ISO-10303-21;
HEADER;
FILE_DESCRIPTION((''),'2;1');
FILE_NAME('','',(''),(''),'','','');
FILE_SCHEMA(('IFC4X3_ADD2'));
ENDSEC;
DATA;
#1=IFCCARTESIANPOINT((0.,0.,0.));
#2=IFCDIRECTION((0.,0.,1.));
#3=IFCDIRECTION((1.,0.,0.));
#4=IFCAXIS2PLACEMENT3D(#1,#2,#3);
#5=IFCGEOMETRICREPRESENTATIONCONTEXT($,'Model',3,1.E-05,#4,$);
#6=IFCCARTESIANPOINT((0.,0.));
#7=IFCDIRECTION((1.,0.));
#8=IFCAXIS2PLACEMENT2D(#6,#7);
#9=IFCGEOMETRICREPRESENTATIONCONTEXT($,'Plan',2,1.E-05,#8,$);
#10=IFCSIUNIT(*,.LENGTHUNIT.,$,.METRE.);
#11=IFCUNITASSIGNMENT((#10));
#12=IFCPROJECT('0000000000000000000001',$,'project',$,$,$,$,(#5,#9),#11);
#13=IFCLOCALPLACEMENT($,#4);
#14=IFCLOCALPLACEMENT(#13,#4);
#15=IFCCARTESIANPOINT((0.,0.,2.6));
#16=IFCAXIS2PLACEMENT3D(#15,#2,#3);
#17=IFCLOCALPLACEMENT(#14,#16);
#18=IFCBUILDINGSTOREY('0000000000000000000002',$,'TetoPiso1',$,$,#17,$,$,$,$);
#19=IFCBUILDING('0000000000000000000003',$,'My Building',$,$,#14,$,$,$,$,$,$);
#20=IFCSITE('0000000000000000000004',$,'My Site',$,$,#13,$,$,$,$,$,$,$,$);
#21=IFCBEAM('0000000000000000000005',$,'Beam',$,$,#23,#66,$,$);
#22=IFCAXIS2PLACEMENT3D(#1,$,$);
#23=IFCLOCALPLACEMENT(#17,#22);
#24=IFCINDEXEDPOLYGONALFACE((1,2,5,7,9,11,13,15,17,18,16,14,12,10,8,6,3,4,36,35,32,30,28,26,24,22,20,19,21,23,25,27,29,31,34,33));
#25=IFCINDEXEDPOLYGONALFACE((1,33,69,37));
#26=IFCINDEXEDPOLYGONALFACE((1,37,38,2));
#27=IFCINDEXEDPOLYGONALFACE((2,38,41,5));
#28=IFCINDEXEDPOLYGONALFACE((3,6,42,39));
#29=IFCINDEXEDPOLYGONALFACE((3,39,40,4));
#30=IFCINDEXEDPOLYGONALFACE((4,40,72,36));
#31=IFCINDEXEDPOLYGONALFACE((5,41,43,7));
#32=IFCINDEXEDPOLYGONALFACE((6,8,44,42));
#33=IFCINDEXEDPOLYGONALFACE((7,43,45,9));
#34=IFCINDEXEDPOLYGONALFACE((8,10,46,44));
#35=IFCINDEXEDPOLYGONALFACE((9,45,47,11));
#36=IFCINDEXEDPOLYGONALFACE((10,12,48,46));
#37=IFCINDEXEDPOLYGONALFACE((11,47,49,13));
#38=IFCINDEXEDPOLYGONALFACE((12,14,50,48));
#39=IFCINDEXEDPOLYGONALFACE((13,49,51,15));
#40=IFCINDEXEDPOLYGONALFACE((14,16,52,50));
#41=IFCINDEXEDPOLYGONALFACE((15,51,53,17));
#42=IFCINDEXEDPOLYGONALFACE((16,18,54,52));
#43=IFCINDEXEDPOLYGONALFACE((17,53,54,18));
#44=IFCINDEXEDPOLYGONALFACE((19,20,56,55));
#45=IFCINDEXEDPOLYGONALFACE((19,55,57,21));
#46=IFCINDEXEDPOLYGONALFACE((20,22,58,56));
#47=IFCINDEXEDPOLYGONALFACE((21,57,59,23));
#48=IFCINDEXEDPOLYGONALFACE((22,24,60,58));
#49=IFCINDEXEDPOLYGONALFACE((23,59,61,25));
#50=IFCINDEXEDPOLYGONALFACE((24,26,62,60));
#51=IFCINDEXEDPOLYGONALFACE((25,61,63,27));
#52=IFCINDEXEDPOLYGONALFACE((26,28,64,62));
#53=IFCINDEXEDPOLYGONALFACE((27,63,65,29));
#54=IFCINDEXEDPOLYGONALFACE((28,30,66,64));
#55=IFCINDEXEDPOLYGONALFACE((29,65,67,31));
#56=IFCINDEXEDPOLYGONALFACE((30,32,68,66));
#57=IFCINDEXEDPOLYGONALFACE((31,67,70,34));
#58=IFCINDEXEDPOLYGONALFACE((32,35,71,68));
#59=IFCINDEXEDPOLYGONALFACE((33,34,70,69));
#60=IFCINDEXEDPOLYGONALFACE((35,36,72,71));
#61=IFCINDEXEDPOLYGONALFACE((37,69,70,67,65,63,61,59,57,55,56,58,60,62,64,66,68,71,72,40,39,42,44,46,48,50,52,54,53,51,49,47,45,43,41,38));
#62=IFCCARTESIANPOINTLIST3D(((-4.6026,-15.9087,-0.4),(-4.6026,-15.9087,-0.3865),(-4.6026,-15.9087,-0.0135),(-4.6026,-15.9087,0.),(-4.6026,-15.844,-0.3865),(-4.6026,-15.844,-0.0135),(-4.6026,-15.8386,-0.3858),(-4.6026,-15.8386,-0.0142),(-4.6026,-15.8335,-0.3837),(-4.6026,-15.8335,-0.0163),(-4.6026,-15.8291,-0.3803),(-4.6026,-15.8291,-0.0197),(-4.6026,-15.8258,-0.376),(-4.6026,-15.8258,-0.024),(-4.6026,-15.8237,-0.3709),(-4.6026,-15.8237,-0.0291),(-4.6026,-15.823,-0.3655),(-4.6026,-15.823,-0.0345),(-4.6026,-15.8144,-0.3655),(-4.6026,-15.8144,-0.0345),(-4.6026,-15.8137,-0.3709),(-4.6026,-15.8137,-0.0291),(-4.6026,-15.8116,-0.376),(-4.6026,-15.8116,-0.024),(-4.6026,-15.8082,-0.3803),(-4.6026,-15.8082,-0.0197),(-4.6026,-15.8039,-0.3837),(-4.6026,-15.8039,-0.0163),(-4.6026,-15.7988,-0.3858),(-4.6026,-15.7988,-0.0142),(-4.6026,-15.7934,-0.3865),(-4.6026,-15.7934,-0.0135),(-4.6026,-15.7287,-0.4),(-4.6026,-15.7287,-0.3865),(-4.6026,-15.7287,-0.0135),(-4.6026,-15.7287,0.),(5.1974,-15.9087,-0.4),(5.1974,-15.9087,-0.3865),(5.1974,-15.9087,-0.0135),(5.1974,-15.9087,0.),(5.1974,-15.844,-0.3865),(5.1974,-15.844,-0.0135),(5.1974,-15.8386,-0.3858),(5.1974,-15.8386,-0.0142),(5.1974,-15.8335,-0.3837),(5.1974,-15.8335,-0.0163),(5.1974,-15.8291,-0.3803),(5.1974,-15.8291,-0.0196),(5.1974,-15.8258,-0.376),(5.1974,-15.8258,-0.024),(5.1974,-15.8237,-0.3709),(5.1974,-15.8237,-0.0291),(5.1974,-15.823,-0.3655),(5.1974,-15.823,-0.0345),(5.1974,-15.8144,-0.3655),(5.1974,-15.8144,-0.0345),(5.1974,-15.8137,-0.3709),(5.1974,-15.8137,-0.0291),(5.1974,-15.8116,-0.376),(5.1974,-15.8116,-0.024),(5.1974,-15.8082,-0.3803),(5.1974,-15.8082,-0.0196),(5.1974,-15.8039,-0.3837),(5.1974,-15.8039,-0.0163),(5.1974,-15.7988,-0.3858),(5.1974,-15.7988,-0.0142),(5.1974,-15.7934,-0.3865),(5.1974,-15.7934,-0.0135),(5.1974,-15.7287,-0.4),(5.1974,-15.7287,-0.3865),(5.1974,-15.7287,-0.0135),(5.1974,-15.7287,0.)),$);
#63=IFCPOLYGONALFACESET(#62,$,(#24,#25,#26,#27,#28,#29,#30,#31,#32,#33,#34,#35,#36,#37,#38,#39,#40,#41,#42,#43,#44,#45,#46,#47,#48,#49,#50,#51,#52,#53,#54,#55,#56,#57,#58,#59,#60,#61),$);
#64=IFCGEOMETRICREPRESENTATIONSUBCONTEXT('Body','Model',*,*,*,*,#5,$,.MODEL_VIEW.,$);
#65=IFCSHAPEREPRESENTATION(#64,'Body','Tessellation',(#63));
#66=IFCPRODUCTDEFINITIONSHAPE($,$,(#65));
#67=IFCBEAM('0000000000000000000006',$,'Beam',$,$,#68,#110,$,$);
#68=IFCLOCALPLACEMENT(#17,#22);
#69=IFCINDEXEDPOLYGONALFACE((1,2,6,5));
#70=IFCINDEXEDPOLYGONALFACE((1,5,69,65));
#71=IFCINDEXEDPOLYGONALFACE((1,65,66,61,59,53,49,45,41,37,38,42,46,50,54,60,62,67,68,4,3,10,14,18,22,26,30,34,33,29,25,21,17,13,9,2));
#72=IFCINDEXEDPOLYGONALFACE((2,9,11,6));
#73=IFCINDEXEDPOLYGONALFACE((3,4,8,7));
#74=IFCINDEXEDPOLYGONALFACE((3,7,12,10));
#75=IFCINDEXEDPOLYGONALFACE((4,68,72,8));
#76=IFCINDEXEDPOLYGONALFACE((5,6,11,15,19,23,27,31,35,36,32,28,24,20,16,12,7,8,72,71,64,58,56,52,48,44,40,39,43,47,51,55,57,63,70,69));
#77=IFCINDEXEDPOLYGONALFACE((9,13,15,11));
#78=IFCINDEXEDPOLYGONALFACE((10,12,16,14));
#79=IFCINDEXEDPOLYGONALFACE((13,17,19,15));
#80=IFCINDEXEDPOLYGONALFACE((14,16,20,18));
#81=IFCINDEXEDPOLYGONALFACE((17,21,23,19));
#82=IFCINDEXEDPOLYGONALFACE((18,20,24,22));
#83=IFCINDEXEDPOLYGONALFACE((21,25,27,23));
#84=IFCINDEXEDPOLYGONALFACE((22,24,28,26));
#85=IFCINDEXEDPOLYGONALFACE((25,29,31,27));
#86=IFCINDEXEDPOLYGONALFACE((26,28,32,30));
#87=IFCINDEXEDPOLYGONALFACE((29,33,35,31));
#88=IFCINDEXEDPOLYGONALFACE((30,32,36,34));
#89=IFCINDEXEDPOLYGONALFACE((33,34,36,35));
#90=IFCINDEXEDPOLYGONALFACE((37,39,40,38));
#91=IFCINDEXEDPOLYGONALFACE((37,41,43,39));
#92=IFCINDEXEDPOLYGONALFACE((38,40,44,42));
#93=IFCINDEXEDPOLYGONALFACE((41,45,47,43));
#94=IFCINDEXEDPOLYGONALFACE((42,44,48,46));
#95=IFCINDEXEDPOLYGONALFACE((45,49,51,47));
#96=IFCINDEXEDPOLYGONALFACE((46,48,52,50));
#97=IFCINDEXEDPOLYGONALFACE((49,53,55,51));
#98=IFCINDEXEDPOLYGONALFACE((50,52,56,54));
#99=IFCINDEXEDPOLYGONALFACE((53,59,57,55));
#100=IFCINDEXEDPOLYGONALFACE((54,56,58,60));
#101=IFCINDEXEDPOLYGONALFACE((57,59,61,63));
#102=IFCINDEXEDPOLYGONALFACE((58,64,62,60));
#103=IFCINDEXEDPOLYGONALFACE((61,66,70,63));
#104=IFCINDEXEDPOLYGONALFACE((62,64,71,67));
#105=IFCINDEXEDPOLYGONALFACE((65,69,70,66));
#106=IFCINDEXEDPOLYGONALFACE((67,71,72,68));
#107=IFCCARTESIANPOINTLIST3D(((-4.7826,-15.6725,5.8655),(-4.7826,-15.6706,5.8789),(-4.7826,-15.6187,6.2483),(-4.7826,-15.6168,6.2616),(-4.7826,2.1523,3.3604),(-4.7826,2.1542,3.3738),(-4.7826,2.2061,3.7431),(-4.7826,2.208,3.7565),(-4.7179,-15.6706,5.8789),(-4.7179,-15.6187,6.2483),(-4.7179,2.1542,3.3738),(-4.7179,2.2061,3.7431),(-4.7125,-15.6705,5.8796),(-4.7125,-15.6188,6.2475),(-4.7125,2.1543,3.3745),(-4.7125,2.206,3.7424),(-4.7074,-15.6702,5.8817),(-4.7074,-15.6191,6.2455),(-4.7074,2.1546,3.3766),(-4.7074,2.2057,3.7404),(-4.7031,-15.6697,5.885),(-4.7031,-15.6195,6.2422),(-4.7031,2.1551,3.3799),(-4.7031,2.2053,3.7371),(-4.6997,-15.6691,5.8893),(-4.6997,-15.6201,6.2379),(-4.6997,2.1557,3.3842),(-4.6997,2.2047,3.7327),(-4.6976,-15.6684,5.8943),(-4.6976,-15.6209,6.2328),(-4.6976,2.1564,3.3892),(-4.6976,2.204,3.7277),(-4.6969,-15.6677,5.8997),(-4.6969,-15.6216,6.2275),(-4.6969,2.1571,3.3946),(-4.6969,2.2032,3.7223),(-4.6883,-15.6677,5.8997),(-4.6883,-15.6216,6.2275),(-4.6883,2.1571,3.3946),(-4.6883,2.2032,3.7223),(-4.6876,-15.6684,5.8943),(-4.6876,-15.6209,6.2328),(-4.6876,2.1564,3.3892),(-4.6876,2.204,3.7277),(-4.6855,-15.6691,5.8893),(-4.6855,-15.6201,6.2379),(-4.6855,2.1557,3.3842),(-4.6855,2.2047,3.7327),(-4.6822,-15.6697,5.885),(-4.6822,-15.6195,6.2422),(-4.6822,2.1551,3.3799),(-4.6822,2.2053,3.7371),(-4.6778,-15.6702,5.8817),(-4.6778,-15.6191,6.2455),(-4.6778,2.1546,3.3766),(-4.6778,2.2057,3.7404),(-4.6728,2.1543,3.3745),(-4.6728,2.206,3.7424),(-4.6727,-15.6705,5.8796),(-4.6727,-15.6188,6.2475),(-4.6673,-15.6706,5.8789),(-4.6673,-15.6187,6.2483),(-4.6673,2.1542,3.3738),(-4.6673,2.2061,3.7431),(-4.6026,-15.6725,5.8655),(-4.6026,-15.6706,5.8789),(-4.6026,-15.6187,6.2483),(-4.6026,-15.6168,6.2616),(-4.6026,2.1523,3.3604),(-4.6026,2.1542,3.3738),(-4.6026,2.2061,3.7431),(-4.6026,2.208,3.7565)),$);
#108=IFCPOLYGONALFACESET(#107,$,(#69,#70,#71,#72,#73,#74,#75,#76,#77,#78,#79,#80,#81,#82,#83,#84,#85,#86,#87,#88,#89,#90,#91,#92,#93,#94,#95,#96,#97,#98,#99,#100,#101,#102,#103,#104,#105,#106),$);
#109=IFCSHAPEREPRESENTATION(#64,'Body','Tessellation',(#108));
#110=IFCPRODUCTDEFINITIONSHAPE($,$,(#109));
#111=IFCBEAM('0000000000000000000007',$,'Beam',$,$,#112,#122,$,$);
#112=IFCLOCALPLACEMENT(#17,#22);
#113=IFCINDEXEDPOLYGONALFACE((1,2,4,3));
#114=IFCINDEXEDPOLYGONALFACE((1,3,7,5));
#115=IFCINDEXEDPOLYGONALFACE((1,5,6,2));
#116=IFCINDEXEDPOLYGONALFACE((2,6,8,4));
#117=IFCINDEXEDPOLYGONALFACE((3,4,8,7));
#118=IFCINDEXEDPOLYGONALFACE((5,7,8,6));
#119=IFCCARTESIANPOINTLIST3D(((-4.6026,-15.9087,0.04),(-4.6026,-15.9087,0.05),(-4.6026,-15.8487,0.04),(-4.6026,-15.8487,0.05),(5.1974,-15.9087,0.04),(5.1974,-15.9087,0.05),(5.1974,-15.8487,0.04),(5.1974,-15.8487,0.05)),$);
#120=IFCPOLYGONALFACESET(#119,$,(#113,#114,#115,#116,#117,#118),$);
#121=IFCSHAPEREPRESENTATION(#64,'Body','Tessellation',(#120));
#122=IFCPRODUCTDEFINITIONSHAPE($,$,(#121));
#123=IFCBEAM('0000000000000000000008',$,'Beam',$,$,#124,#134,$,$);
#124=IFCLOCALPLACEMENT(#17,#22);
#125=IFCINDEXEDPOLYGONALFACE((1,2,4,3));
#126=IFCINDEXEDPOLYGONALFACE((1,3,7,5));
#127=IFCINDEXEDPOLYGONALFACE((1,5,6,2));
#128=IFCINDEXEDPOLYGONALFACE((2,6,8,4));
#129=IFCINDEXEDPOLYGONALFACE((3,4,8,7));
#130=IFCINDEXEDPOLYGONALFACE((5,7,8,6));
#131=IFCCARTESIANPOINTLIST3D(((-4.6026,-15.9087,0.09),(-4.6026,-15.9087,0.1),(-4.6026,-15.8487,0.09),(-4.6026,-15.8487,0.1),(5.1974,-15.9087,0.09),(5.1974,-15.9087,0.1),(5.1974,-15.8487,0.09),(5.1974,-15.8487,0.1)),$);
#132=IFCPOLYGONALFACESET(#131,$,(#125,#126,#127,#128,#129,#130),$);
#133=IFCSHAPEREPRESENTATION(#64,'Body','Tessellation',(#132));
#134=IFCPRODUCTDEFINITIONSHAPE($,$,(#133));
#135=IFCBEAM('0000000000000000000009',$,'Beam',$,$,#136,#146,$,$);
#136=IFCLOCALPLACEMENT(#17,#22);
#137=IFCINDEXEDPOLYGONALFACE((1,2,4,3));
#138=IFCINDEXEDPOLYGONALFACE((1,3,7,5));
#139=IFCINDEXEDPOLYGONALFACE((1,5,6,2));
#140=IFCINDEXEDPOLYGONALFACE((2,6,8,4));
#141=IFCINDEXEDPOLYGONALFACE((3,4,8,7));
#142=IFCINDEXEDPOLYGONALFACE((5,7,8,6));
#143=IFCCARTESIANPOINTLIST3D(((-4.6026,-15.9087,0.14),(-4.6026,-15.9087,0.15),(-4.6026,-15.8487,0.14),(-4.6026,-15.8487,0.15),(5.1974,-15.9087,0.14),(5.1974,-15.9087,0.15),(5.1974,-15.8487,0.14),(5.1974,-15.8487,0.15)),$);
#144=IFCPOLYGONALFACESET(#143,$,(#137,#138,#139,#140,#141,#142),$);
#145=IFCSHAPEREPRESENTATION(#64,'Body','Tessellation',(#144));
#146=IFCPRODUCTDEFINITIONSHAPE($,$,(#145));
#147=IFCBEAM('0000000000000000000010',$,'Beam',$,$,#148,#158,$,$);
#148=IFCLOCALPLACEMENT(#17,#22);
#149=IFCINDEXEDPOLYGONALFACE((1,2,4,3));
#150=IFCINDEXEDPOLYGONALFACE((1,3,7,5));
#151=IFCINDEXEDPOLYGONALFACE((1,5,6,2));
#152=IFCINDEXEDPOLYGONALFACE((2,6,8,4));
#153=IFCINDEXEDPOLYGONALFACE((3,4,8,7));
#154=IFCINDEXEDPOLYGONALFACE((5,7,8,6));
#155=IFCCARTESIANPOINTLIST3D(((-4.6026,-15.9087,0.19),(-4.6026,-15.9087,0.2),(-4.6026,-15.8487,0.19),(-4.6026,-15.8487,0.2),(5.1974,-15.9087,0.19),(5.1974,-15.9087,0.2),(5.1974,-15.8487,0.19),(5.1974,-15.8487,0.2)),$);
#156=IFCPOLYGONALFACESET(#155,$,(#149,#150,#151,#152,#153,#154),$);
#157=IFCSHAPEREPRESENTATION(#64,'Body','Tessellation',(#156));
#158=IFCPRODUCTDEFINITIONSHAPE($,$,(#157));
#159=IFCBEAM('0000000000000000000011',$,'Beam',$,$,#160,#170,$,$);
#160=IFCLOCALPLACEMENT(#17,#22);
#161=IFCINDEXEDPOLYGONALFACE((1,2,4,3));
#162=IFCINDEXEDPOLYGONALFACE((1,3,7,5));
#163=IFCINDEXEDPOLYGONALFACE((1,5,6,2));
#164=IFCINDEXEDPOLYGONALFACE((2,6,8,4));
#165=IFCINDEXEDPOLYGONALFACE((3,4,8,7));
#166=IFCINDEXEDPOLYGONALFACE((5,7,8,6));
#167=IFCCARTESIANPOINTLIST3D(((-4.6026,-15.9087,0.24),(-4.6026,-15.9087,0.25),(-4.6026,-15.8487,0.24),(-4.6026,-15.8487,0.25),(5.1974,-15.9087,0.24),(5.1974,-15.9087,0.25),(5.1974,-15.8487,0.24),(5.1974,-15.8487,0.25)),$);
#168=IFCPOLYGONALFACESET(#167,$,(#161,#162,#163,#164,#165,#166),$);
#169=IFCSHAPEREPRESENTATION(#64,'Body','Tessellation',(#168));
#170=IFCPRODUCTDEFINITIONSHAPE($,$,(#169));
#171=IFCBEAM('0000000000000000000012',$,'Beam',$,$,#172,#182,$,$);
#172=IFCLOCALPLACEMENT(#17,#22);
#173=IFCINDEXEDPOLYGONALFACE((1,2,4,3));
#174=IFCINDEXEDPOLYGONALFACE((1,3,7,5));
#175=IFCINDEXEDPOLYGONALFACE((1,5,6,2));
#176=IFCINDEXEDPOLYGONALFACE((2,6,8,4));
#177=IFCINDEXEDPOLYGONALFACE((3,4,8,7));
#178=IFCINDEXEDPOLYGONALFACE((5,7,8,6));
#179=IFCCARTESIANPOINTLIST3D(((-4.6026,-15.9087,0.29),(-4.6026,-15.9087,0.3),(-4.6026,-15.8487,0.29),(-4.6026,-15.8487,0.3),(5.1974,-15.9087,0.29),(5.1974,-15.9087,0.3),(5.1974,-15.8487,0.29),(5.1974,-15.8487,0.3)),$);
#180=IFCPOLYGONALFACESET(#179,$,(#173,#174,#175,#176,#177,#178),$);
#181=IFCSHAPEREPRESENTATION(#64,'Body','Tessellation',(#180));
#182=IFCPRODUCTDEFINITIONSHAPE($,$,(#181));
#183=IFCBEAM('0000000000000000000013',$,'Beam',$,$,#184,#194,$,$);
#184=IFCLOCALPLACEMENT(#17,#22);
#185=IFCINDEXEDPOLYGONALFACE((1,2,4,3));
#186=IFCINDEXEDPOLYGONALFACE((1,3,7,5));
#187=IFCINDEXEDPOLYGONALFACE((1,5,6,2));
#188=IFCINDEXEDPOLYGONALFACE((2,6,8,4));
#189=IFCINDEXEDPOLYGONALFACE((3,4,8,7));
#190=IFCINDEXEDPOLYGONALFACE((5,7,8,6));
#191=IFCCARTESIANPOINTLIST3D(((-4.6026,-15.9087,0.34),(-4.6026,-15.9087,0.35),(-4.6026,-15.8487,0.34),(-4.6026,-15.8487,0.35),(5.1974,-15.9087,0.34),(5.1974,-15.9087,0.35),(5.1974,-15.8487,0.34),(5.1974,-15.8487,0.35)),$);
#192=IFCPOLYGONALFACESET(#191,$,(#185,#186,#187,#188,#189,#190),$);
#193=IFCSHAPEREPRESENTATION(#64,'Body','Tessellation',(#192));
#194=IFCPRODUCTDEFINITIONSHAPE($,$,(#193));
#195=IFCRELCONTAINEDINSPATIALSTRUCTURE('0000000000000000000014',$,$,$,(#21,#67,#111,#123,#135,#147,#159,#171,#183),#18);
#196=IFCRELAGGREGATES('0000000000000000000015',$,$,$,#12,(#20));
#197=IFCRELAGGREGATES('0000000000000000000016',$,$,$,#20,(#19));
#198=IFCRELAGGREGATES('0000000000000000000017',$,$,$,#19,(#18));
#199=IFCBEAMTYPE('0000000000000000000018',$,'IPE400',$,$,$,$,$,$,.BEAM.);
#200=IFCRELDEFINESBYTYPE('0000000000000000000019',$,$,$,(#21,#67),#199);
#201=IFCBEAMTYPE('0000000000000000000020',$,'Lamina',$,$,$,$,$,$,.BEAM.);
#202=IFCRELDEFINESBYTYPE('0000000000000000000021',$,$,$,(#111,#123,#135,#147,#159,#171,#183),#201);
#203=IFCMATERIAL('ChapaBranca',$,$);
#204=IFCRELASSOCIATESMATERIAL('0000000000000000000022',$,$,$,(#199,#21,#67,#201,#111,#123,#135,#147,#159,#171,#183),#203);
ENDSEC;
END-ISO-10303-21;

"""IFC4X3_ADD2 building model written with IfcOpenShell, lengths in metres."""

from ifc_helpers import new_model, si_unit, frame, origin_with_axes, origin_2d, origin_2d_with_axis, place, context, subcontext, project, spatial, rectangle, i_section, extrude, material, material_profile, profile_set, profile_usage, type_object, element, save


model = new_model("IFC4X3_ADD2")

# Units and contexts
model_context = context("Model", 3, precision=1e-05, world=origin_with_axes())
plan_context = context("Plan", 2, precision=1e-05, world=origin_2d_with_axis())
body_context = subcontext(model_context, "Body", "Model", "MODEL_VIEW")
ifc_project = project(units=[si_unit("LENGTHUNIT", "METRE")], contexts=[model_context, plan_context])

# Site, building, storey
site_placement = place(None, origin_with_axes())
site = spatial("IfcSite", under=ifc_project, at=site_placement, Name="My Site")
building_placement = place(site_placement, origin_with_axes())
building = spatial("IfcBuilding", under=site, at=building_placement, Name="My Building")
storey_placement = place(building_placement, frame((0.0, 0.0, 2.6), z_axis=(0.0, 0.0, 1.0), x_axis=(1.0, 0.0, 0.0)))
storey = spatial("IfcBuildingStorey", under=building, at=storey_placement, Name="TetoPiso1")

# Beams
ifc_material_1 = material(Name="ChapaBranca")
ifc_material_profile_1 = material_profile(ifc_material_1, i_section(OverallWidth=0.18, OverallDepth=0.4, WebThickness=0.0086, FlangeThickness=0.0135, FilletRadius=0.021))
ifc_profile_set_1 = profile_set([ifc_material_profile_1])
ifc_profile_usage_1 = profile_usage(ifc_profile_set_1, cardinal=5)
beam_type_1 = type_object("IfcBeamType", Name="IPE400", PredefinedType="BEAM", material=ifc_profile_set_1)
beam_1_placement = place(storey_placement, frame((-4.6026, -15.8187, -0.2), z_axis=(1.0, 0.0, 0.0), x_axis=(0.0, 1.0, 0.0)))
element("IfcBeam", 1, at=beam_1_placement, inside=storey, type_object=beam_type_1, material=ifc_profile_usage_1, Name="Beam", context=body_context, shape_type="SweptSolid", body=[
    extrude(i_section(OverallWidth=0.18, OverallDepth=0.4, WebThickness=0.0086, FlangeThickness=0.0135, FilletRadius=0.021), origin_with_axes(), (0.0, 0.0, 1.0), 9.8),
])
ifc_profile_usage_2 = profile_usage(ifc_profile_set_1, cardinal=8)
beam_2_placement = place(storey_placement, frame((-4.6926, -15.6168, 6.2616), z_axis=(0.0, 0.990268, -0.139173), x_axis=(-1.0, 0.0, 0.0)))
element("IfcBeam", 2, at=beam_2_placement, inside=storey, type_object=beam_type_1, material=ifc_profile_usage_2, Name="Beam", context=body_context, shape_type="SweptSolid", body=[
    extrude(i_section(OverallWidth=0.18, OverallDepth=0.4, WebThickness=0.0086, FlangeThickness=0.0135, FilletRadius=0.021), frame((0.0, -0.2, 0.0), z_axis=(0.0, 0.0, 1.0), x_axis=(1.0, 0.0, 0.0)), (0.0, 0.0, 1.0), 18.0),
])
ifc_material_profile_2 = material_profile(ifc_material_1, rectangle(XDim=0.06, YDim=0.01, at=origin_2d()))
ifc_profile_set_2 = profile_set([ifc_material_profile_2])
ifc_profile_usage_3 = profile_usage(ifc_profile_set_2, cardinal=5)
beam_type_2 = type_object("IfcBeamType", Name="Lamina", PredefinedType="BEAM", material=ifc_profile_set_2)
beam_3_placement = place(storey_placement, frame((-4.6026, -15.8787, 0.045), z_axis=(1.0, 0.0, 0.0), x_axis=(0.0, 1.0, 0.0)))
element("IfcBeam", 3, at=beam_3_placement, inside=storey, type_object=beam_type_2, material=ifc_profile_usage_3, Name="Beam", context=body_context, shape_type="SweptSolid", body=[
    extrude(rectangle(XDim=0.06, YDim=0.01, at=origin_2d()), origin_with_axes(), (0.0, 0.0, 1.0), 9.8),
])
ifc_profile_usage_4 = profile_usage(ifc_profile_set_2, cardinal=5)
beam_4_placement = place(storey_placement, frame((-4.6026, -15.8787, 0.095), z_axis=(1.0, 0.0, 0.0), x_axis=(0.0, 1.0, 0.0)))
element("IfcBeam", 4, at=beam_4_placement, inside=storey, type_object=beam_type_2, material=ifc_profile_usage_4, Name="Beam", context=body_context, shape_type="SweptSolid", body=[
    extrude(rectangle(XDim=0.06, YDim=0.01, at=origin_2d()), origin_with_axes(), (0.0, 0.0, 1.0), 9.8),
])
ifc_profile_usage_5 = profile_usage(ifc_profile_set_2, cardinal=5)
beam_5_placement = place(storey_placement, frame((-4.6026, -15.8787, 0.145), z_axis=(1.0, 0.0, 0.0), x_axis=(0.0, 1.0, 0.0)))
element("IfcBeam", 5, at=beam_5_placement, inside=storey, type_object=beam_type_2, material=ifc_profile_usage_5, Name="Beam", context=body_context, shape_type="SweptSolid", body=[
    extrude(rectangle(XDim=0.06, YDim=0.01, at=origin_2d()), origin_with_axes(), (0.0, 0.0, 1.0), 9.8),
])
ifc_profile_usage_6 = profile_usage(ifc_profile_set_2, cardinal=5)
beam_6_placement = place(storey_placement, frame((-4.6026, -15.8787, 0.195), z_axis=(1.0, 0.0, 0.0), x_axis=(0.0, 1.0, 0.0)))
element("IfcBeam", 6, at=beam_6_placement, inside=storey, type_object=beam_type_2, material=ifc_profile_usage_6, Name="Beam", context=body_context, shape_type="SweptSolid", body=[
    extrude(rectangle(XDim=0.06, YDim=0.01, at=origin_2d()), origin_with_axes(), (0.0, 0.0, 1.0), 9.8),
])
ifc_profile_usage_7 = profile_usage(ifc_profile_set_2, cardinal=5)
beam_7_placement = place(storey_placement, frame((-4.6026, -15.8787, 0.245), z_axis=(1.0, 0.0, 0.0), x_axis=(0.0, 1.0, 0.0)))
element("IfcBeam", 7, at=beam_7_placement, inside=storey, type_object=beam_type_2, material=ifc_profile_usage_7, Name="Beam", context=body_context, shape_type="SweptSolid", body=[
    extrude(rectangle(XDim=0.06, YDim=0.01, at=origin_2d()), origin_with_axes(), (0.0, 0.0, 1.0), 9.8),
])
ifc_profile_usage_8 = profile_usage(ifc_profile_set_2, cardinal=5)
beam_8_placement = place(storey_placement, frame((-4.6026, -15.8787, 0.295), z_axis=(1.0, 0.0, 0.0), x_axis=(0.0, 1.0, 0.0)))
element("IfcBeam", 8, at=beam_8_placement, inside=storey, type_object=beam_type_2, material=ifc_profile_usage_8, Name="Beam", context=body_context, shape_type="SweptSolid", body=[
    extrude(rectangle(XDim=0.06, YDim=0.01, at=origin_2d()), origin_with_axes(), (0.0, 0.0, 1.0), 9.8),
])
ifc_profile_usage_9 = profile_usage(ifc_profile_set_2, cardinal=5)
beam_9_placement = place(storey_placement, frame((-4.6026, -15.8787, 0.345), z_axis=(1.0, 0.0, 0.0), x_axis=(0.0, 1.0, 0.0)))
element("IfcBeam", 9, at=beam_9_placement, inside=storey, type_object=beam_type_2, material=ifc_profile_usage_9, Name="Beam", context=body_context, shape_type="SweptSolid", body=[
    extrude(rectangle(XDim=0.06, YDim=0.01, at=origin_2d()), origin_with_axes(), (0.0, 0.0, 1.0), 9.8),
])

save(model, "model.ifc")
